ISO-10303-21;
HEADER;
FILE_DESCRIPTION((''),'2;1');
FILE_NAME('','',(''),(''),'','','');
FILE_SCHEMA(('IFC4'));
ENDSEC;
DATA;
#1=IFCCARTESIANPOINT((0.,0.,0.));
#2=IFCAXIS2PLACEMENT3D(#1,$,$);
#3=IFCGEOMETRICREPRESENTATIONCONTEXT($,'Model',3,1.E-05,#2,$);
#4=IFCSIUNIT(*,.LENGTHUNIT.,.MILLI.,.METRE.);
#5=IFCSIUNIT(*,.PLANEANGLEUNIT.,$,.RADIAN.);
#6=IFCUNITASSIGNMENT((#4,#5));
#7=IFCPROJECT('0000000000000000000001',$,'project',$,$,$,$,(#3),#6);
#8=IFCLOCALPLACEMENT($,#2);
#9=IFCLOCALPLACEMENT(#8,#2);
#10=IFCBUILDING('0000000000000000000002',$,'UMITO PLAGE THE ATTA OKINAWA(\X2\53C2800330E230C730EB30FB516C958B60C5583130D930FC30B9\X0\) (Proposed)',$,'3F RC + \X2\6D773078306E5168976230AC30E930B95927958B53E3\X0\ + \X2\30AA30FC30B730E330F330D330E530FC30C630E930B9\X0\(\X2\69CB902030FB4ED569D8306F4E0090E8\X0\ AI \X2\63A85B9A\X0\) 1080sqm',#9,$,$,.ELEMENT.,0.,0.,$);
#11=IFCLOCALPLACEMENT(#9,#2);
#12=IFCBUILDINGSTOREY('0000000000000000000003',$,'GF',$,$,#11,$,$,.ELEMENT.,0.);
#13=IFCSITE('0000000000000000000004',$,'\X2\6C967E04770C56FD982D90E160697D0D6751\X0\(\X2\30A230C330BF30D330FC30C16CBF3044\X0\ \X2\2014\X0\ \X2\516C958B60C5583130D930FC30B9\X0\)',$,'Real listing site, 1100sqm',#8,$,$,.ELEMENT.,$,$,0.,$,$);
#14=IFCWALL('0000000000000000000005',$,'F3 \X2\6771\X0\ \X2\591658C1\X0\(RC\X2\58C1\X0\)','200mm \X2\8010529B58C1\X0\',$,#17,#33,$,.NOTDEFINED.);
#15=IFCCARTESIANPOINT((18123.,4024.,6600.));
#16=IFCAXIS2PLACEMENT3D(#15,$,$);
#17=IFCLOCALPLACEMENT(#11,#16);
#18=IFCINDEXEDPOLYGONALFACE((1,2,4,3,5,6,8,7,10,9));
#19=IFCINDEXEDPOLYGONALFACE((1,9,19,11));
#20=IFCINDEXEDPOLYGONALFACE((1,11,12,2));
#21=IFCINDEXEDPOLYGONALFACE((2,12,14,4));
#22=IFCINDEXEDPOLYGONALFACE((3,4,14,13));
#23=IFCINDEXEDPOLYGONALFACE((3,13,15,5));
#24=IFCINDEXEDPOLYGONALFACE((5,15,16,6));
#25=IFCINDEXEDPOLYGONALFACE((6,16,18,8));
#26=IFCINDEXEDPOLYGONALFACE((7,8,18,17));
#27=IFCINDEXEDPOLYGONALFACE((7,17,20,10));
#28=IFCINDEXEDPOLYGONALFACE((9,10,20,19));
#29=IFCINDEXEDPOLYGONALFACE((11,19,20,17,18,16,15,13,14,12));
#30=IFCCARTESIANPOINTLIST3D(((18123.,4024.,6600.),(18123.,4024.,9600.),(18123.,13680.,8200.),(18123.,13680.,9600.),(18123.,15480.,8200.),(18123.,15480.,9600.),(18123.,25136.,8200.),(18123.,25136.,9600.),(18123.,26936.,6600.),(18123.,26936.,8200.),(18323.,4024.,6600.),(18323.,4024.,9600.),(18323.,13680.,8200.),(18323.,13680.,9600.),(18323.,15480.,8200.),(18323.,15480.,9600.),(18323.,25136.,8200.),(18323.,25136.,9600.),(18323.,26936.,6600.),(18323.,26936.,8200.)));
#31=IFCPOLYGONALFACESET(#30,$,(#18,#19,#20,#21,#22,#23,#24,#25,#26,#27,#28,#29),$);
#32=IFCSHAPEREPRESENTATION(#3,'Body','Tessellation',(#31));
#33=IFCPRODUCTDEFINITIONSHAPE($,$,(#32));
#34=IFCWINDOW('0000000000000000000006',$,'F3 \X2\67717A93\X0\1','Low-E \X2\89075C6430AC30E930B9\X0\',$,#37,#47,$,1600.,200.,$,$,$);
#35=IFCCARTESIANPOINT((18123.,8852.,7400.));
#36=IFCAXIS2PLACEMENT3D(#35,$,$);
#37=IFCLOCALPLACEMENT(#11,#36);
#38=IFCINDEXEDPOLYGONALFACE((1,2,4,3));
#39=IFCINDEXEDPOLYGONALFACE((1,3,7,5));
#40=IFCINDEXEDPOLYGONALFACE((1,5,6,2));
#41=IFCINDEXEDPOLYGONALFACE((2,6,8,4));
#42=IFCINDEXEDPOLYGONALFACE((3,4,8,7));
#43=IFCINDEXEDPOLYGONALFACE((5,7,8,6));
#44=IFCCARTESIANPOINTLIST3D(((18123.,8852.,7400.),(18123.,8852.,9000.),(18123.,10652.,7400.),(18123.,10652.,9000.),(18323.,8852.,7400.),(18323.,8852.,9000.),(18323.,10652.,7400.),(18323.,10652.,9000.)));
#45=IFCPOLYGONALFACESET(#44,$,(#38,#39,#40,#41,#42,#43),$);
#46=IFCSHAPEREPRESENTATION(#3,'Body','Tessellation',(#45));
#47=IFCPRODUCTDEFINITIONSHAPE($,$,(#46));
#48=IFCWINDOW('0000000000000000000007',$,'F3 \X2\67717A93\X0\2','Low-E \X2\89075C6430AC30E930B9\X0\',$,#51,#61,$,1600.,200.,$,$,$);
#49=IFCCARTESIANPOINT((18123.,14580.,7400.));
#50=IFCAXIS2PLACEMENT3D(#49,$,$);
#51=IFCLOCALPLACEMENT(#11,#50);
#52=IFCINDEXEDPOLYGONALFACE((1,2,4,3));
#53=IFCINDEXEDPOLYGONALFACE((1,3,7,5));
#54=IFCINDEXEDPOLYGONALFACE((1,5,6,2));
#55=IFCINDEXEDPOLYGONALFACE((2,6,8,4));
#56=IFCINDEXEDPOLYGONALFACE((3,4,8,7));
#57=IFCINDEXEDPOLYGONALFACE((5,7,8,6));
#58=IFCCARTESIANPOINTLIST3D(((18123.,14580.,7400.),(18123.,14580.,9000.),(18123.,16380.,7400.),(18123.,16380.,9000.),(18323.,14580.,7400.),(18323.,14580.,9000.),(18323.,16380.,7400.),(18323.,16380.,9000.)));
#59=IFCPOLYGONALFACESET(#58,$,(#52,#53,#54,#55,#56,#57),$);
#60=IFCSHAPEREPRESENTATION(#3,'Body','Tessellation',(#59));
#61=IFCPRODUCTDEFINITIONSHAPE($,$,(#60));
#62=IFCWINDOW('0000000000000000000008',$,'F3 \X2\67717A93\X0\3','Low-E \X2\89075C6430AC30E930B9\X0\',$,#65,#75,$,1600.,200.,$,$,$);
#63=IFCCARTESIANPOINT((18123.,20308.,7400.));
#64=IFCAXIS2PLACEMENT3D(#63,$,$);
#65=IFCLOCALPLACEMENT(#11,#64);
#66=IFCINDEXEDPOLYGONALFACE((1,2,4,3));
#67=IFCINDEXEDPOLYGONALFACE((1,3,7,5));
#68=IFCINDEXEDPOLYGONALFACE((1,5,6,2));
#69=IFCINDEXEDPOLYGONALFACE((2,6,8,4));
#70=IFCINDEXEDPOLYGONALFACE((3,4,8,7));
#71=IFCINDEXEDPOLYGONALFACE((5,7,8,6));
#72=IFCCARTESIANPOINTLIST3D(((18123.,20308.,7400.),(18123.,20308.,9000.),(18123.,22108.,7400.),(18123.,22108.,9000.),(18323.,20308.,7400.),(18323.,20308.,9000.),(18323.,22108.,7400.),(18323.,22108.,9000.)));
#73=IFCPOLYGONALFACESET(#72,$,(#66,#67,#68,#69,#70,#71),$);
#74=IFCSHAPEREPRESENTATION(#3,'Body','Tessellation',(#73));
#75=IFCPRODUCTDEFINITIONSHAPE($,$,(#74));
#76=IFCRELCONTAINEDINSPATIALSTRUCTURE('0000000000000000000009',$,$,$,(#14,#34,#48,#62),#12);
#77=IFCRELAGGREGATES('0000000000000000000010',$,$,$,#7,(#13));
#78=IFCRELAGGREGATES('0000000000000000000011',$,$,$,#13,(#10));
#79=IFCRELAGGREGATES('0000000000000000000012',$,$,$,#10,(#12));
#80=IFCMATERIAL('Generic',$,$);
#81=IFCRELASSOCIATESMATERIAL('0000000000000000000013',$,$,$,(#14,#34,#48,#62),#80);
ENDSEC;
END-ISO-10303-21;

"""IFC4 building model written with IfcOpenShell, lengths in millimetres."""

from ifc_helpers import new_model, si_unit, frame, frame_2d, origin, place, context, project, spatial, rectangle, extrude, material, element, fill, save


model = new_model("IFC4")

# Units and contexts
model_context = context("Model", 3, precision=1e-05, world=origin())
ifc_project = project(units=[si_unit("LENGTHUNIT", "METRE", prefix="MILLI"), si_unit("PLANEANGLEUNIT", "RADIAN")], contexts=[model_context])

# Site, building, storey
site_placement = place(None, origin())
site = spatial("IfcSite", under=ifc_project, at=site_placement, Name="沖縄県国頭郡恩納村(アッタビーチ沿い — 公開情報ベース)", ObjectType="Real listing site, 1100sqm", CompositionType="ELEMENT", RefElevation=0.0)
building_placement = place(site_placement, origin())
building = spatial("IfcBuilding", under=site, at=building_placement, Name="UMITO PLAGE THE ATTA OKINAWA(参考モデル・公開情報ベース) (Proposed)", ObjectType="3F RC + 海への全面ガラス大開口 + オーシャンビューテラス(構造・仕様は一部 AI 推定) 1080sqm", CompositionType="ELEMENT", ElevationOfRefHeight=0.0, ElevationOfTerrain=0.0)
storey_placement = place(building_placement, origin())
storey = spatial("IfcBuildingStorey", under=building, at=storey_placement, Name="GF", CompositionType="ELEMENT", Elevation=0.0)

# Shared definitions
ifc_material = material(Name="Generic")

# Wall, openings, windows
wall_1_placement = place(storey_placement, frame((18123.0, 4024.0, 6600.0)))
wall_1 = element("IfcWall", 1, at=wall_1_placement, inside=storey, material=ifc_material, Name="F3 東 外壁(RC壁)", Description="200mm 耐力壁", PredefinedType="NOTDEFINED", context=model_context, shape_type="SweptSolid", body=[
    extrude(rectangle(XDim=200.0, YDim=22912.0, at=frame_2d((100.0, 11456.0))), frame((18123.0, 4024.0, 6600.0)), (0.0, 0.0, 1.0), 3000.0),
])
opening_1_placement = place(storey_placement, frame((18123.0, 8852.0, 7400.0)))
opening_1 = element("IfcOpeningElement", 2, at=opening_1_placement, cuts=wall_1, PredefinedType="NOTDEFINED", context=model_context, shape_type="SweptSolid", body=[
    extrude(rectangle(XDim=200.0, YDim=1800.0, at=frame_2d((100.0, 900.0))), frame((18123.0, 8852.0, 7400.0)), (0.0, 0.0, 1.0), 1600.0),
])
opening_2_placement = place(storey_placement, frame((18123.0, 14580.0, 7400.0)))
opening_2 = element("IfcOpeningElement", 3, at=opening_2_placement, cuts=wall_1, PredefinedType="NOTDEFINED", context=model_context, shape_type="SweptSolid", body=[
    extrude(rectangle(XDim=200.0, YDim=1800.0, at=frame_2d((100.0, 900.0))), frame((18123.0, 14580.0, 7400.0)), (0.0, 0.0, 1.0), 1600.0),
])
opening_3_placement = place(storey_placement, frame((18123.0, 20308.0, 7400.0)))
opening_3 = element("IfcOpeningElement", 4, at=opening_3_placement, cuts=wall_1, PredefinedType="NOTDEFINED", context=model_context, shape_type="SweptSolid", body=[
    extrude(rectangle(XDim=200.0, YDim=1800.0, at=frame_2d((100.0, 900.0))), frame((18123.0, 20308.0, 7400.0)), (0.0, 0.0, 1.0), 1600.0),
])
window_1_placement = place(storey_placement, frame((18123.0, 8852.0, 7400.0)))
window_1 = element("IfcWindow", 5, at=window_1_placement, inside=storey, material=ifc_material, Name="F3 東窓1", Description="Low-E 複層ガラス", OverallHeight=1600.0, OverallWidth=200.0, context=model_context, shape_type="SweptSolid", body=[
    extrude(rectangle(XDim=200.0, YDim=1800.0, at=frame_2d((100.0, 900.0))), frame((18123.0, 8852.0, 7400.0)), (0.0, 0.0, 1.0), 1600.0),
])
fill(opening_1, window_1)
window_2_placement = place(storey_placement, frame((18123.0, 14580.0, 7400.0)))
window_2 = element("IfcWindow", 6, at=window_2_placement, inside=storey, material=ifc_material, Name="F3 東窓2", Description="Low-E 複層ガラス", OverallHeight=1600.0, OverallWidth=200.0, context=model_context, shape_type="SweptSolid", body=[
    extrude(rectangle(XDim=200.0, YDim=1800.0, at=frame_2d((100.0, 900.0))), frame((18123.0, 14580.0, 7400.0)), (0.0, 0.0, 1.0), 1600.0),
])
fill(opening_2, window_2)
window_3_placement = place(storey_placement, frame((18123.0, 20308.0, 7400.0)))
window_3 = element("IfcWindow", 7, at=window_3_placement, inside=storey, material=ifc_material, Name="F3 東窓3", Description="Low-E 複層ガラス", OverallHeight=1600.0, OverallWidth=200.0, context=model_context, shape_type="SweptSolid", body=[
    extrude(rectangle(XDim=200.0, YDim=1800.0, at=frame_2d((100.0, 900.0))), frame((18123.0, 20308.0, 7400.0)), (0.0, 0.0, 1.0), 1600.0),
])
fill(opening_3, window_3)

save(model, "model.ifc")
